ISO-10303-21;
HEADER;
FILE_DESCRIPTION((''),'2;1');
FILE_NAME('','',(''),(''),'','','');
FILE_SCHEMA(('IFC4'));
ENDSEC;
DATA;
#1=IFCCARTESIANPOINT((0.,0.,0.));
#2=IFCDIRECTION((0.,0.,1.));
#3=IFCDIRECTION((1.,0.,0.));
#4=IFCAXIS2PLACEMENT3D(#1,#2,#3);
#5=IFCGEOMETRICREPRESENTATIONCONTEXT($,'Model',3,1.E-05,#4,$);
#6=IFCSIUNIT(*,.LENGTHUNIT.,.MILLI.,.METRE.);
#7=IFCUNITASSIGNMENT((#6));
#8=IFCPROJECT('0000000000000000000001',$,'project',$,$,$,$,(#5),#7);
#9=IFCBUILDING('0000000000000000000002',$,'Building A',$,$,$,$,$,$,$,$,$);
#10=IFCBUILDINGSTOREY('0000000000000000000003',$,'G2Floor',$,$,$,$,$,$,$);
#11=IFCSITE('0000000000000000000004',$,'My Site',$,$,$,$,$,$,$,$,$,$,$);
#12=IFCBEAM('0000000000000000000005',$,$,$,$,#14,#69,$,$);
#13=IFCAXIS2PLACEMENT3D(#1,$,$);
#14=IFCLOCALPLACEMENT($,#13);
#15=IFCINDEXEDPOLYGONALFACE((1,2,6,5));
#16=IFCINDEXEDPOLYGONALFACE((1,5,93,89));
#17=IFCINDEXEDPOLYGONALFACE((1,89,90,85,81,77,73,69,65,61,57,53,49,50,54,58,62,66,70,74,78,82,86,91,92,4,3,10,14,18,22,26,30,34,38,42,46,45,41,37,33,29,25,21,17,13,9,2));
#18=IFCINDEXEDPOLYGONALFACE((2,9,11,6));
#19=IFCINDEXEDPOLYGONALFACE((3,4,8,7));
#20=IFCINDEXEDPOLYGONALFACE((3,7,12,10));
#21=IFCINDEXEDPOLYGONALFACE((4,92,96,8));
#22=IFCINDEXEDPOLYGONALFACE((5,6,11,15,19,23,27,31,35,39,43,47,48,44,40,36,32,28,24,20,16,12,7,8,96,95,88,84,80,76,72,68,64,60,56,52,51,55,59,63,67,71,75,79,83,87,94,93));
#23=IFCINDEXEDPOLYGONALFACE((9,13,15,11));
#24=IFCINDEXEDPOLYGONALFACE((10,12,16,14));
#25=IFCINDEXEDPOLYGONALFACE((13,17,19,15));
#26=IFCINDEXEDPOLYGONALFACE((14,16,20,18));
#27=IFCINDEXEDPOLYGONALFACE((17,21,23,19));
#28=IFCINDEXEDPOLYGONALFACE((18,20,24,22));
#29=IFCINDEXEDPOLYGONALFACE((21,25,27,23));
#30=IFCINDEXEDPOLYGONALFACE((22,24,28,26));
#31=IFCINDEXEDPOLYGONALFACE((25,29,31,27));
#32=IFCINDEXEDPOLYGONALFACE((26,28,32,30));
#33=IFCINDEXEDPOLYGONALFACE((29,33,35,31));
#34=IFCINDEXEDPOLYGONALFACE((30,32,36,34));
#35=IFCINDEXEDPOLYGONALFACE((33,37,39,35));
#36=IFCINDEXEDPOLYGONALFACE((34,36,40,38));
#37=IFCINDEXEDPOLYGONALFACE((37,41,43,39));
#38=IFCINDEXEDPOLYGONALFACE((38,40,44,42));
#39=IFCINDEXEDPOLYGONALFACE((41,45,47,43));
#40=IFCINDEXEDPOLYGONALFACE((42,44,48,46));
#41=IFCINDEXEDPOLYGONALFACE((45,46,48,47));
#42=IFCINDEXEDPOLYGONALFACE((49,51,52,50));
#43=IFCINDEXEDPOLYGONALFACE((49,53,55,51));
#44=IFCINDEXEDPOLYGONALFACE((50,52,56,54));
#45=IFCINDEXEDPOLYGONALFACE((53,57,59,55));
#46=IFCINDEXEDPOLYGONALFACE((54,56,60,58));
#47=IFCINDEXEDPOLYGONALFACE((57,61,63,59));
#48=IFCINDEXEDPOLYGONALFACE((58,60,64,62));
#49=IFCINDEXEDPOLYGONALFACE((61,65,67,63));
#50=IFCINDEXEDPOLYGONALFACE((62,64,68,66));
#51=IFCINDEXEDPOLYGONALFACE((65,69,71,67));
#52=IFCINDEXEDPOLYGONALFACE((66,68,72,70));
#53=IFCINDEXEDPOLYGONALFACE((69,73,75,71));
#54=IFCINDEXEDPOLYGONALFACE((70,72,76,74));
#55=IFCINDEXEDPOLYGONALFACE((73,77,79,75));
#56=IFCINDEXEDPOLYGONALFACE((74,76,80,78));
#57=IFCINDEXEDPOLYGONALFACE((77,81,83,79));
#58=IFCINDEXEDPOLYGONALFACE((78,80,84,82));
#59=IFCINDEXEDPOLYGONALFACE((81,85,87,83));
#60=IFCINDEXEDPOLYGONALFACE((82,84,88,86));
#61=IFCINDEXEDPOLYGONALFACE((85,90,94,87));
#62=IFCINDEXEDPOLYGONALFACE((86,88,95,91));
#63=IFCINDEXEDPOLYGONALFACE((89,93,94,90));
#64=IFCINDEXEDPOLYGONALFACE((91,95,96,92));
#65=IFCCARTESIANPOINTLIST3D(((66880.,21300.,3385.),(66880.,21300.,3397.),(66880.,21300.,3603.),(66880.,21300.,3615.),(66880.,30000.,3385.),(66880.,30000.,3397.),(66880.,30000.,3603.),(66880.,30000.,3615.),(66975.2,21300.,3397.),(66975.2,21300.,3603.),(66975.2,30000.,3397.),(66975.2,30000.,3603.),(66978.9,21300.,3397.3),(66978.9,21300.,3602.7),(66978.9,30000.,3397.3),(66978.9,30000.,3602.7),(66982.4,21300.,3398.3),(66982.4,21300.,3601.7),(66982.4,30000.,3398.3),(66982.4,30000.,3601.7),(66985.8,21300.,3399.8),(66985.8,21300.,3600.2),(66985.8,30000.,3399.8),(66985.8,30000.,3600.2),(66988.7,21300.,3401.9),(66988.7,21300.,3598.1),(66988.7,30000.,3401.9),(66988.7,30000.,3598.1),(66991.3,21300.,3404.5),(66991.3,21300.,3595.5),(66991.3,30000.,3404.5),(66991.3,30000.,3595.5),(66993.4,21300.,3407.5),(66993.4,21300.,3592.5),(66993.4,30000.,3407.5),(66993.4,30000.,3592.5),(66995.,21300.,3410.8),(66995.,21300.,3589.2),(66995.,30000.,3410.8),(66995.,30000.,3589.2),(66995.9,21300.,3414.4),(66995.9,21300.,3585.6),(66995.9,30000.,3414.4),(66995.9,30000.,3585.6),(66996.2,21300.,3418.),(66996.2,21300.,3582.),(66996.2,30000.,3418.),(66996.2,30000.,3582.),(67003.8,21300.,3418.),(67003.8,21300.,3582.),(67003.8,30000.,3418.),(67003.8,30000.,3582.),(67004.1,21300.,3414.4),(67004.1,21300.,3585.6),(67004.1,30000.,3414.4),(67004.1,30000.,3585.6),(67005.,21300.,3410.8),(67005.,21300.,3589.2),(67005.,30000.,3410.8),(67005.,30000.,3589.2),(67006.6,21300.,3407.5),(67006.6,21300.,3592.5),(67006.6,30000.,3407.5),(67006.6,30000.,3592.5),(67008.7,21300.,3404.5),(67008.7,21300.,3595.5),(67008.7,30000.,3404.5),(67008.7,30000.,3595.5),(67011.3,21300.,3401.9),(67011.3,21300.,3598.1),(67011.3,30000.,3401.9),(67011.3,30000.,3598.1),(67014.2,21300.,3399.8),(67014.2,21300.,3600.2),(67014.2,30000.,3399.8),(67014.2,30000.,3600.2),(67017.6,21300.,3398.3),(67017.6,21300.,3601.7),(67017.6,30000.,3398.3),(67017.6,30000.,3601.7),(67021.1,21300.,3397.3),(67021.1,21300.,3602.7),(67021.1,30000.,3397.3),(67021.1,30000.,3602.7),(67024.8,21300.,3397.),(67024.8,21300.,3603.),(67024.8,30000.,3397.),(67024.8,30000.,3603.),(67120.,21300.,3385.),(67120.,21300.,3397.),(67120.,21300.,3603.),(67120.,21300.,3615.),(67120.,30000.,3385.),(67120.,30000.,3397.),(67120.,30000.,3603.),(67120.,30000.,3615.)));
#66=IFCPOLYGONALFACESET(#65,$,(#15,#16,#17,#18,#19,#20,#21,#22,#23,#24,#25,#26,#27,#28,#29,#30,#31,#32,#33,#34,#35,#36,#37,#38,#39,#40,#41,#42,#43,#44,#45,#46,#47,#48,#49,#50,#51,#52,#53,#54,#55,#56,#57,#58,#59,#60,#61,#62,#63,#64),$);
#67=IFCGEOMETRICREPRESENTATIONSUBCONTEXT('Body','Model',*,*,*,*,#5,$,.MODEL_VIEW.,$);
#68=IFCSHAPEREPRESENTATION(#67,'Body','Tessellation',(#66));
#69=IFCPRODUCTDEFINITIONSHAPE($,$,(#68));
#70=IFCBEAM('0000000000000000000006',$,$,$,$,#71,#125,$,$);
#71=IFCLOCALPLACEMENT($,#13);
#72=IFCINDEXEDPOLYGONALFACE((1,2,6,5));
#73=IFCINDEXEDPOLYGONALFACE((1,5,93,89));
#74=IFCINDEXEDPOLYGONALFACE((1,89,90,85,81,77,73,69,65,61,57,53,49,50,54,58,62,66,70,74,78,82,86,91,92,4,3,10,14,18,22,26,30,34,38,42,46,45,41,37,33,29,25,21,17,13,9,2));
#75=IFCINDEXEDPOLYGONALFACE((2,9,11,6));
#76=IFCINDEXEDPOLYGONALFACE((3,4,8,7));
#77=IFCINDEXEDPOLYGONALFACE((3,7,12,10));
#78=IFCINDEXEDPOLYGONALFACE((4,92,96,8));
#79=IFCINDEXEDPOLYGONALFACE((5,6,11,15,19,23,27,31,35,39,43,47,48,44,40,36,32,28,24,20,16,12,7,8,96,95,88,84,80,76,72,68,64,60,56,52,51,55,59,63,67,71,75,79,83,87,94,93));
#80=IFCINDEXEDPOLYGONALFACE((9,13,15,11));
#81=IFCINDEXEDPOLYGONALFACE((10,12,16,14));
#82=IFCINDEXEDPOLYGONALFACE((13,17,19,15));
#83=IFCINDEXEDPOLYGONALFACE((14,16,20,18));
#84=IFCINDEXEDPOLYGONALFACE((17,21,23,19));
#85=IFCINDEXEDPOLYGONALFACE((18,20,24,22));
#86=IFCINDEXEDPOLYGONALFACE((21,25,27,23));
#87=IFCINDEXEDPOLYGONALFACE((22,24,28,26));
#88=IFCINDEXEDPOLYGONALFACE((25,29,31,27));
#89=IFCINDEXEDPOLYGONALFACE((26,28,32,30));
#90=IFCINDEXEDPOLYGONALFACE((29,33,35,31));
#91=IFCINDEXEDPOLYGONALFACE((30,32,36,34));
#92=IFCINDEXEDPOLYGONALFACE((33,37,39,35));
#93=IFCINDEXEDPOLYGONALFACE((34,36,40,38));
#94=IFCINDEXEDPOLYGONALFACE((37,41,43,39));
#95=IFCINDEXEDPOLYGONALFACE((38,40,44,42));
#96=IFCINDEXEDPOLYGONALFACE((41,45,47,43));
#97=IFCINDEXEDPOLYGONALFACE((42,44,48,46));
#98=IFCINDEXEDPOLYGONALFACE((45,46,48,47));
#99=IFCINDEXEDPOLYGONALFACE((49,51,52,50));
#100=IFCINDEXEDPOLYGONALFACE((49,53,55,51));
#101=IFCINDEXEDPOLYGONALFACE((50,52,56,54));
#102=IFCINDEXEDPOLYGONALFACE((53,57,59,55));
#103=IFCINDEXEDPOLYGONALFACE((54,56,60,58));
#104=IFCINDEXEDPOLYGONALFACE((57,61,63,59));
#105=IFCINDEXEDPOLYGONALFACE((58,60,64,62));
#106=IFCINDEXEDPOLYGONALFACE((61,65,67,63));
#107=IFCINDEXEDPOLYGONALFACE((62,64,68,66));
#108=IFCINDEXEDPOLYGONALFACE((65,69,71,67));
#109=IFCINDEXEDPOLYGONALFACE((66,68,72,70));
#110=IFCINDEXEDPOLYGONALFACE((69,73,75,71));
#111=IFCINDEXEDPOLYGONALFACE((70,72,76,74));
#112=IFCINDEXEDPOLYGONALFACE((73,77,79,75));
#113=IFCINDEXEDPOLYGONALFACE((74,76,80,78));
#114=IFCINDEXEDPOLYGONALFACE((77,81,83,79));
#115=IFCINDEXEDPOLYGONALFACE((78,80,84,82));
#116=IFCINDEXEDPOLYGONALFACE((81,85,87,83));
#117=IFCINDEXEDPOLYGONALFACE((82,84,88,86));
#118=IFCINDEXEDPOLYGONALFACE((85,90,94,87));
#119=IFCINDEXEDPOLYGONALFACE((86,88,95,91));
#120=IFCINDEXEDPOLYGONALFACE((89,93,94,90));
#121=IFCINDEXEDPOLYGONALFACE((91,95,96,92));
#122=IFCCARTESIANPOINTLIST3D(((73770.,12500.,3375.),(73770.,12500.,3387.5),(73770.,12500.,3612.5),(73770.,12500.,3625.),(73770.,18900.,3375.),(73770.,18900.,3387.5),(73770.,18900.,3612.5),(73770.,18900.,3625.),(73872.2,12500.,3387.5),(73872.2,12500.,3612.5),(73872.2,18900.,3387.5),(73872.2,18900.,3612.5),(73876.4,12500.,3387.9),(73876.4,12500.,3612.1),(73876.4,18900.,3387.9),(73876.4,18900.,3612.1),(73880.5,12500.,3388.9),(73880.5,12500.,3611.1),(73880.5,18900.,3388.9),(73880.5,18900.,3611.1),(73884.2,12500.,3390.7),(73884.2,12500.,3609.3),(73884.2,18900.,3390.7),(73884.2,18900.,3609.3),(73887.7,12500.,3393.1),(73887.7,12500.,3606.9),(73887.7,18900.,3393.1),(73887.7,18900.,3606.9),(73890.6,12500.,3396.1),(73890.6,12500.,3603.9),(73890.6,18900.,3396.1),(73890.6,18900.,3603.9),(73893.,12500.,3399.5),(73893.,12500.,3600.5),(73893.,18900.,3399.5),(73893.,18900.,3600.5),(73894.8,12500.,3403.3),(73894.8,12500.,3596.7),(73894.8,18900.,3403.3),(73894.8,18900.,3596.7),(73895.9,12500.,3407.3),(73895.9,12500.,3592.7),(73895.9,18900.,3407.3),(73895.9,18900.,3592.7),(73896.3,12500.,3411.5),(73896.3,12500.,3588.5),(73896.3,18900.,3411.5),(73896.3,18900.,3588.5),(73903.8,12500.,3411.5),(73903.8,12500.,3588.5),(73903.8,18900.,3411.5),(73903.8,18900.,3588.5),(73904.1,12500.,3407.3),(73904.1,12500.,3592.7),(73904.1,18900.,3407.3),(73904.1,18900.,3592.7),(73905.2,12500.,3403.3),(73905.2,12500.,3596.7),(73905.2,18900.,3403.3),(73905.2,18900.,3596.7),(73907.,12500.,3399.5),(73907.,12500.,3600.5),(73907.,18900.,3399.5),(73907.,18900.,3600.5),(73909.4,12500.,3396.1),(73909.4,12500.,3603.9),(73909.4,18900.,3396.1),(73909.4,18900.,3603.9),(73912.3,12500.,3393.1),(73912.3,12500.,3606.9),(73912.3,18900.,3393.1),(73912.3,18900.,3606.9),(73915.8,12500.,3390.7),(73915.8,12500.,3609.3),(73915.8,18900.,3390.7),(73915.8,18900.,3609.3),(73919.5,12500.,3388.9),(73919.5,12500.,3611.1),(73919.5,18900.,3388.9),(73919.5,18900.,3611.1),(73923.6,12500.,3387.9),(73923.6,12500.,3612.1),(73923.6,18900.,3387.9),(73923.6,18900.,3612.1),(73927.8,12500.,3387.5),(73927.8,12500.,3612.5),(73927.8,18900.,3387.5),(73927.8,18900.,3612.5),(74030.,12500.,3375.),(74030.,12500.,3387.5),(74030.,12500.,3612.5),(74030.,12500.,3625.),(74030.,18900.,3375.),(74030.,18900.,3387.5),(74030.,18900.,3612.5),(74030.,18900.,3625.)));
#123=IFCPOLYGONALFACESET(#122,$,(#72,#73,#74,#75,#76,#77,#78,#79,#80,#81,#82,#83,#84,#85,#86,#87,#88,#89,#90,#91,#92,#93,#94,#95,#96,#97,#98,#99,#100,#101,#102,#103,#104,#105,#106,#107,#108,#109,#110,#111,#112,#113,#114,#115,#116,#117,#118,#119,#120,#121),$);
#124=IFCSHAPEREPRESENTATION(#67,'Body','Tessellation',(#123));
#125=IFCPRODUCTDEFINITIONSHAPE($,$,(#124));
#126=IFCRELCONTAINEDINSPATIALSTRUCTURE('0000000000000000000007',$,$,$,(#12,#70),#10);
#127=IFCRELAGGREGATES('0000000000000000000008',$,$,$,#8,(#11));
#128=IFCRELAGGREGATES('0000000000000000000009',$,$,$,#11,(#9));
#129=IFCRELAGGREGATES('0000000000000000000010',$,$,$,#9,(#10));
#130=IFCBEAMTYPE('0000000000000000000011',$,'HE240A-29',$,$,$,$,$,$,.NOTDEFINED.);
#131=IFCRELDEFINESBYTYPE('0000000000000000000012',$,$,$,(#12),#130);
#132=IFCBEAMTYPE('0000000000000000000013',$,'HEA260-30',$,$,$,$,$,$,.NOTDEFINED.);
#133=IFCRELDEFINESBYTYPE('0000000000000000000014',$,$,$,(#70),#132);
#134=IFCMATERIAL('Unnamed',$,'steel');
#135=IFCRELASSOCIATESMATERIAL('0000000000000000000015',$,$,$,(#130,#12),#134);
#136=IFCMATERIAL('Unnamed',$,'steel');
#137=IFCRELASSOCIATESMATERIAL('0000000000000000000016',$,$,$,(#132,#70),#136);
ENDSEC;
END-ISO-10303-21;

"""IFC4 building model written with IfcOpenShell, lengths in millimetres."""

from ifc_helpers import new_model, si_unit, frame, origin_with_axes, place, context, subcontext, project, spatial, polyline, outline, extrude, material, material_profile, profile_set, profile_usage, type_object, element, save


model = new_model("IFC4")

# Units and contexts
model_context = context("Model", 3, precision=1e-05, world=origin_with_axes())
body_context = subcontext(model_context, "Body", "Model", "MODEL_VIEW")
ifc_project = project(units=[si_unit("LENGTHUNIT", "METRE", prefix="MILLI")], contexts=[model_context])

# Site, building, storey
site = spatial("IfcSite", under=ifc_project, Name="My Site")
building = spatial("IfcBuilding", under=site, Name="Building A")
storey = spatial("IfcBuildingStorey", under=building, Name="G2Floor")

# Beams
ifc_material_1 = material(Name="Unnamed", Category="steel")
ifc_material_profile_1 = material_profile(ifc_material_1, outline(polyline([(120.0, -115.0), (120.0, -103.0), (120.0, -103.0), (24.8, -103.0), (24.8, -103.0), (21.1, -102.7), (21.1, -102.7), (17.6, -101.7), (17.6, -101.7), (14.2, -100.2), (14.2, -100.2), (11.3, -98.1), (11.3, -98.1), (8.7, -95.5), (8.7, -95.5), (6.6, -92.5), (6.6, -92.5), (5.0, -89.2), (5.0, -89.2), (4.1, -85.6), (4.1, -85.6), (3.8, -82.0), (3.8, -82.0), (3.8, 82.0), (3.8, 82.0), (4.1, 85.6), (4.1, 85.6), (5.0, 89.2), (5.0, 89.2), (6.6, 92.5), (6.6, 92.5), (8.7, 95.5), (8.7, 95.5), (11.3, 98.1), (11.3, 98.1), (14.2, 100.2), (14.2, 100.2), (17.6, 101.7), (17.6, 101.7), (21.1, 102.7), (21.1, 102.7), (24.8, 103.0), (24.8, 103.0), (120.0, 103.0), (120.0, 103.0), (120.0, 115.0), (120.0, 115.0), (-120.0, 115.0), (-120.0, 115.0), (-120.0, 103.0), (-120.0, 103.0), (-24.8, 103.0), (-24.8, 103.0), (-21.1, 102.7), (-21.1, 102.7), (-17.6, 101.7), (-17.6, 101.7), (-14.2, 100.2), (-14.2, 100.2), (-11.3, 98.1), (-11.3, 98.1), (-8.7, 95.5), (-8.7, 95.5), (-6.6, 92.5), (-6.6, 92.5), (-5.0, 89.2), (-5.0, 89.2), (-4.1, 85.6), (-4.1, 85.6), (-3.8, 82.0), (-3.8, 82.0), (-3.8, -82.0), (-3.8, -82.0), (-4.1, -85.6), (-4.1, -85.6), (-5.0, -89.2), (-5.0, -89.2), (-6.6, -92.5), (-6.6, -92.5), (-8.7, -95.5), (-8.7, -95.5), (-11.3, -98.1), (-11.3, -98.1), (-14.2, -100.2), (-14.2, -100.2), (-17.6, -101.7), (-17.6, -101.7), (-21.1, -102.7), (-21.1, -102.7), (-24.8, -103.0), (-24.8, -103.0), (-120.0, -103.0), (-120.0, -103.0), (-120.0, -115.0), (-120.0, -115.0), (120.0, -115.0)])))
ifc_profile_set_1 = profile_set([ifc_material_profile_1], Name="HE240A-29")
ifc_profile_usage_1 = profile_usage(ifc_profile_set_1)
beam_type_1 = type_object("IfcBeamType", Name="HE240A-29", PredefinedType="NOTDEFINED", material=ifc_profile_set_1)
beam_1_placement = place(None, frame((67000.0, 21300.0, 3500.0), z_axis=(0.0, 1.0, 0.0), x_axis=(1.0, 0.0, 0.0)))
element("IfcBeam", 1, at=beam_1_placement, inside=storey, type_object=beam_type_1, material=ifc_profile_usage_1, context=body_context, shape_type="SweptSolid", body=[
    extrude(outline(polyline([(120.0, -115.0), (120.0, -103.0), (120.0, -103.0), (24.8, -103.0), (24.8, -103.0), (21.1, -102.7), (21.1, -102.7), (17.6, -101.7), (17.6, -101.7), (14.2, -100.2), (14.2, -100.2), (11.3, -98.1), (11.3, -98.1), (8.7, -95.5), (8.7, -95.5), (6.6, -92.5), (6.6, -92.5), (5.0, -89.2), (5.0, -89.2), (4.1, -85.6), (4.1, -85.6), (3.8, -82.0), (3.8, -82.0), (3.8, 82.0), (3.8, 82.0), (4.1, 85.6), (4.1, 85.6), (5.0, 89.2), (5.0, 89.2), (6.6, 92.5), (6.6, 92.5), (8.7, 95.5), (8.7, 95.5), (11.3, 98.1), (11.3, 98.1), (14.2, 100.2), (14.2, 100.2), (17.6, 101.7), (17.6, 101.7), (21.1, 102.7), (21.1, 102.7), (24.8, 103.0), (24.8, 103.0), (120.0, 103.0), (120.0, 103.0), (120.0, 115.0), (120.0, 115.0), (-120.0, 115.0), (-120.0, 115.0), (-120.0, 103.0), (-120.0, 103.0), (-24.8, 103.0), (-24.8, 103.0), (-21.1, 102.7), (-21.1, 102.7), (-17.6, 101.7), (-17.6, 101.7), (-14.2, 100.2), (-14.2, 100.2), (-11.3, 98.1), (-11.3, 98.1), (-8.7, 95.5), (-8.7, 95.5), (-6.6, 92.5), (-6.6, 92.5), (-5.0, 89.2), (-5.0, 89.2), (-4.1, 85.6), (-4.1, 85.6), (-3.8, 82.0), (-3.8, 82.0), (-3.8, -82.0), (-3.8, -82.0), (-4.1, -85.6), (-4.1, -85.6), (-5.0, -89.2), (-5.0, -89.2), (-6.6, -92.5), (-6.6, -92.5), (-8.7, -95.5), (-8.7, -95.5), (-11.3, -98.1), (-11.3, -98.1), (-14.2, -100.2), (-14.2, -100.2), (-17.6, -101.7), (-17.6, -101.7), (-21.1, -102.7), (-21.1, -102.7), (-24.8, -103.0), (-24.8, -103.0), (-120.0, -103.0), (-120.0, -103.0), (-120.0, -115.0), (-120.0, -115.0), (120.0, -115.0)])), origin_with_axes(), (0.0, 0.0, 1.0), 8700.0),
])
ifc_material_2 = material(Name="Unnamed", Category="steel")
ifc_material_profile_2 = material_profile(ifc_material_2, outline(polyline([(130.0, -125.0), (130.0, -112.5), (130.0, -112.5), (27.8, -112.5), (27.8, -112.5), (23.6, -112.1), (23.6, -112.1), (19.5, -111.1), (19.5, -111.1), (15.8, -109.3), (15.8, -109.3), (12.3, -106.9), (12.3, -106.9), (9.4, -103.9), (9.4, -103.9), (7.0, -100.5), (7.0, -100.5), (5.2, -96.7), (5.2, -96.7), (4.1, -92.7), (4.1, -92.7), (3.8, -88.5), (3.8, -88.5), (3.8, 88.5), (3.8, 88.5), (4.1, 92.7), (4.1, 92.7), (5.2, 96.7), (5.2, 96.7), (7.0, 100.5), (7.0, 100.5), (9.4, 103.9), (9.4, 103.9), (12.3, 106.9), (12.3, 106.9), (15.8, 109.3), (15.8, 109.3), (19.5, 111.1), (19.5, 111.1), (23.6, 112.1), (23.6, 112.1), (27.8, 112.5), (27.8, 112.5), (130.0, 112.5), (130.0, 112.5), (130.0, 125.0), (130.0, 125.0), (-130.0, 125.0), (-130.0, 125.0), (-130.0, 112.5), (-130.0, 112.5), (-27.8, 112.5), (-27.8, 112.5), (-23.6, 112.1), (-23.6, 112.1), (-19.5, 111.1), (-19.5, 111.1), (-15.8, 109.3), (-15.8, 109.3), (-12.3, 106.9), (-12.3, 106.9), (-9.4, 103.9), (-9.4, 103.9), (-7.0, 100.5), (-7.0, 100.5), (-5.2, 96.7), (-5.2, 96.7), (-4.1, 92.7), (-4.1, 92.7), (-3.8, 88.5), (-3.8, 88.5), (-3.8, -88.5), (-3.8, -88.5), (-4.1, -92.7), (-4.1, -92.7), (-5.2, -96.7), (-5.2, -96.7), (-7.0, -100.5), (-7.0, -100.5), (-9.4, -103.9), (-9.4, -103.9), (-12.3, -106.9), (-12.3, -106.9), (-15.8, -109.3), (-15.8, -109.3), (-19.5, -111.1), (-19.5, -111.1), (-23.6, -112.1), (-23.6, -112.1), (-27.8, -112.5), (-27.8, -112.5), (-130.0, -112.5), (-130.0, -112.5), (-130.0, -125.0), (-130.0, -125.0), (130.0, -125.0)])))
ifc_profile_set_2 = profile_set([ifc_material_profile_2], Name="HEA260-30")
ifc_profile_usage_2 = profile_usage(ifc_profile_set_2)
beam_type_2 = type_object("IfcBeamType", Name="HEA260-30", PredefinedType="NOTDEFINED", material=ifc_profile_set_2)
beam_2_placement = place(None, frame((73900.0, 12500.0, 3500.0), z_axis=(0.0, 1.0, 0.0), x_axis=(1.0, 0.0, 0.0)))
element("IfcBeam", 2, at=beam_2_placement, inside=storey, type_object=beam_type_2, material=ifc_profile_usage_2, context=body_context, shape_type="SweptSolid", body=[
    extrude(outline(polyline([(130.0, -125.0), (130.0, -112.5), (130.0, -112.5), (27.8, -112.5), (27.8, -112.5), (23.6, -112.1), (23.6, -112.1), (19.5, -111.1), (19.5, -111.1), (15.8, -109.3), (15.8, -109.3), (12.3, -106.9), (12.3, -106.9), (9.4, -103.9), (9.4, -103.9), (7.0, -100.5), (7.0, -100.5), (5.2, -96.7), (5.2, -96.7), (4.1, -92.7), (4.1, -92.7), (3.8, -88.5), (3.8, -88.5), (3.8, 88.5), (3.8, 88.5), (4.1, 92.7), (4.1, 92.7), (5.2, 96.7), (5.2, 96.7), (7.0, 100.5), (7.0, 100.5), (9.4, 103.9), (9.4, 103.9), (12.3, 106.9), (12.3, 106.9), (15.8, 109.3), (15.8, 109.3), (19.5, 111.1), (19.5, 111.1), (23.6, 112.1), (23.6, 112.1), (27.8, 112.5), (27.8, 112.5), (130.0, 112.5), (130.0, 112.5), (130.0, 125.0), (130.0, 125.0), (-130.0, 125.0), (-130.0, 125.0), (-130.0, 112.5), (-130.0, 112.5), (-27.8, 112.5), (-27.8, 112.5), (-23.6, 112.1), (-23.6, 112.1), (-19.5, 111.1), (-19.5, 111.1), (-15.8, 109.3), (-15.8, 109.3), (-12.3, 106.9), (-12.3, 106.9), (-9.4, 103.9), (-9.4, 103.9), (-7.0, 100.5), (-7.0, 100.5), (-5.2, 96.7), (-5.2, 96.7), (-4.1, 92.7), (-4.1, 92.7), (-3.8, 88.5), (-3.8, 88.5), (-3.8, -88.5), (-3.8, -88.5), (-4.1, -92.7), (-4.1, -92.7), (-5.2, -96.7), (-5.2, -96.7), (-7.0, -100.5), (-7.0, -100.5), (-9.4, -103.9), (-9.4, -103.9), (-12.3, -106.9), (-12.3, -106.9), (-15.8, -109.3), (-15.8, -109.3), (-19.5, -111.1), (-19.5, -111.1), (-23.6, -112.1), (-23.6, -112.1), (-27.8, -112.5), (-27.8, -112.5), (-130.0, -112.5), (-130.0, -112.5), (-130.0, -125.0), (-130.0, -125.0), (130.0, -125.0)])), origin_with_axes(), (0.0, 0.0, 1.0), 6400.0),
])

save(model, "model.ifc")
